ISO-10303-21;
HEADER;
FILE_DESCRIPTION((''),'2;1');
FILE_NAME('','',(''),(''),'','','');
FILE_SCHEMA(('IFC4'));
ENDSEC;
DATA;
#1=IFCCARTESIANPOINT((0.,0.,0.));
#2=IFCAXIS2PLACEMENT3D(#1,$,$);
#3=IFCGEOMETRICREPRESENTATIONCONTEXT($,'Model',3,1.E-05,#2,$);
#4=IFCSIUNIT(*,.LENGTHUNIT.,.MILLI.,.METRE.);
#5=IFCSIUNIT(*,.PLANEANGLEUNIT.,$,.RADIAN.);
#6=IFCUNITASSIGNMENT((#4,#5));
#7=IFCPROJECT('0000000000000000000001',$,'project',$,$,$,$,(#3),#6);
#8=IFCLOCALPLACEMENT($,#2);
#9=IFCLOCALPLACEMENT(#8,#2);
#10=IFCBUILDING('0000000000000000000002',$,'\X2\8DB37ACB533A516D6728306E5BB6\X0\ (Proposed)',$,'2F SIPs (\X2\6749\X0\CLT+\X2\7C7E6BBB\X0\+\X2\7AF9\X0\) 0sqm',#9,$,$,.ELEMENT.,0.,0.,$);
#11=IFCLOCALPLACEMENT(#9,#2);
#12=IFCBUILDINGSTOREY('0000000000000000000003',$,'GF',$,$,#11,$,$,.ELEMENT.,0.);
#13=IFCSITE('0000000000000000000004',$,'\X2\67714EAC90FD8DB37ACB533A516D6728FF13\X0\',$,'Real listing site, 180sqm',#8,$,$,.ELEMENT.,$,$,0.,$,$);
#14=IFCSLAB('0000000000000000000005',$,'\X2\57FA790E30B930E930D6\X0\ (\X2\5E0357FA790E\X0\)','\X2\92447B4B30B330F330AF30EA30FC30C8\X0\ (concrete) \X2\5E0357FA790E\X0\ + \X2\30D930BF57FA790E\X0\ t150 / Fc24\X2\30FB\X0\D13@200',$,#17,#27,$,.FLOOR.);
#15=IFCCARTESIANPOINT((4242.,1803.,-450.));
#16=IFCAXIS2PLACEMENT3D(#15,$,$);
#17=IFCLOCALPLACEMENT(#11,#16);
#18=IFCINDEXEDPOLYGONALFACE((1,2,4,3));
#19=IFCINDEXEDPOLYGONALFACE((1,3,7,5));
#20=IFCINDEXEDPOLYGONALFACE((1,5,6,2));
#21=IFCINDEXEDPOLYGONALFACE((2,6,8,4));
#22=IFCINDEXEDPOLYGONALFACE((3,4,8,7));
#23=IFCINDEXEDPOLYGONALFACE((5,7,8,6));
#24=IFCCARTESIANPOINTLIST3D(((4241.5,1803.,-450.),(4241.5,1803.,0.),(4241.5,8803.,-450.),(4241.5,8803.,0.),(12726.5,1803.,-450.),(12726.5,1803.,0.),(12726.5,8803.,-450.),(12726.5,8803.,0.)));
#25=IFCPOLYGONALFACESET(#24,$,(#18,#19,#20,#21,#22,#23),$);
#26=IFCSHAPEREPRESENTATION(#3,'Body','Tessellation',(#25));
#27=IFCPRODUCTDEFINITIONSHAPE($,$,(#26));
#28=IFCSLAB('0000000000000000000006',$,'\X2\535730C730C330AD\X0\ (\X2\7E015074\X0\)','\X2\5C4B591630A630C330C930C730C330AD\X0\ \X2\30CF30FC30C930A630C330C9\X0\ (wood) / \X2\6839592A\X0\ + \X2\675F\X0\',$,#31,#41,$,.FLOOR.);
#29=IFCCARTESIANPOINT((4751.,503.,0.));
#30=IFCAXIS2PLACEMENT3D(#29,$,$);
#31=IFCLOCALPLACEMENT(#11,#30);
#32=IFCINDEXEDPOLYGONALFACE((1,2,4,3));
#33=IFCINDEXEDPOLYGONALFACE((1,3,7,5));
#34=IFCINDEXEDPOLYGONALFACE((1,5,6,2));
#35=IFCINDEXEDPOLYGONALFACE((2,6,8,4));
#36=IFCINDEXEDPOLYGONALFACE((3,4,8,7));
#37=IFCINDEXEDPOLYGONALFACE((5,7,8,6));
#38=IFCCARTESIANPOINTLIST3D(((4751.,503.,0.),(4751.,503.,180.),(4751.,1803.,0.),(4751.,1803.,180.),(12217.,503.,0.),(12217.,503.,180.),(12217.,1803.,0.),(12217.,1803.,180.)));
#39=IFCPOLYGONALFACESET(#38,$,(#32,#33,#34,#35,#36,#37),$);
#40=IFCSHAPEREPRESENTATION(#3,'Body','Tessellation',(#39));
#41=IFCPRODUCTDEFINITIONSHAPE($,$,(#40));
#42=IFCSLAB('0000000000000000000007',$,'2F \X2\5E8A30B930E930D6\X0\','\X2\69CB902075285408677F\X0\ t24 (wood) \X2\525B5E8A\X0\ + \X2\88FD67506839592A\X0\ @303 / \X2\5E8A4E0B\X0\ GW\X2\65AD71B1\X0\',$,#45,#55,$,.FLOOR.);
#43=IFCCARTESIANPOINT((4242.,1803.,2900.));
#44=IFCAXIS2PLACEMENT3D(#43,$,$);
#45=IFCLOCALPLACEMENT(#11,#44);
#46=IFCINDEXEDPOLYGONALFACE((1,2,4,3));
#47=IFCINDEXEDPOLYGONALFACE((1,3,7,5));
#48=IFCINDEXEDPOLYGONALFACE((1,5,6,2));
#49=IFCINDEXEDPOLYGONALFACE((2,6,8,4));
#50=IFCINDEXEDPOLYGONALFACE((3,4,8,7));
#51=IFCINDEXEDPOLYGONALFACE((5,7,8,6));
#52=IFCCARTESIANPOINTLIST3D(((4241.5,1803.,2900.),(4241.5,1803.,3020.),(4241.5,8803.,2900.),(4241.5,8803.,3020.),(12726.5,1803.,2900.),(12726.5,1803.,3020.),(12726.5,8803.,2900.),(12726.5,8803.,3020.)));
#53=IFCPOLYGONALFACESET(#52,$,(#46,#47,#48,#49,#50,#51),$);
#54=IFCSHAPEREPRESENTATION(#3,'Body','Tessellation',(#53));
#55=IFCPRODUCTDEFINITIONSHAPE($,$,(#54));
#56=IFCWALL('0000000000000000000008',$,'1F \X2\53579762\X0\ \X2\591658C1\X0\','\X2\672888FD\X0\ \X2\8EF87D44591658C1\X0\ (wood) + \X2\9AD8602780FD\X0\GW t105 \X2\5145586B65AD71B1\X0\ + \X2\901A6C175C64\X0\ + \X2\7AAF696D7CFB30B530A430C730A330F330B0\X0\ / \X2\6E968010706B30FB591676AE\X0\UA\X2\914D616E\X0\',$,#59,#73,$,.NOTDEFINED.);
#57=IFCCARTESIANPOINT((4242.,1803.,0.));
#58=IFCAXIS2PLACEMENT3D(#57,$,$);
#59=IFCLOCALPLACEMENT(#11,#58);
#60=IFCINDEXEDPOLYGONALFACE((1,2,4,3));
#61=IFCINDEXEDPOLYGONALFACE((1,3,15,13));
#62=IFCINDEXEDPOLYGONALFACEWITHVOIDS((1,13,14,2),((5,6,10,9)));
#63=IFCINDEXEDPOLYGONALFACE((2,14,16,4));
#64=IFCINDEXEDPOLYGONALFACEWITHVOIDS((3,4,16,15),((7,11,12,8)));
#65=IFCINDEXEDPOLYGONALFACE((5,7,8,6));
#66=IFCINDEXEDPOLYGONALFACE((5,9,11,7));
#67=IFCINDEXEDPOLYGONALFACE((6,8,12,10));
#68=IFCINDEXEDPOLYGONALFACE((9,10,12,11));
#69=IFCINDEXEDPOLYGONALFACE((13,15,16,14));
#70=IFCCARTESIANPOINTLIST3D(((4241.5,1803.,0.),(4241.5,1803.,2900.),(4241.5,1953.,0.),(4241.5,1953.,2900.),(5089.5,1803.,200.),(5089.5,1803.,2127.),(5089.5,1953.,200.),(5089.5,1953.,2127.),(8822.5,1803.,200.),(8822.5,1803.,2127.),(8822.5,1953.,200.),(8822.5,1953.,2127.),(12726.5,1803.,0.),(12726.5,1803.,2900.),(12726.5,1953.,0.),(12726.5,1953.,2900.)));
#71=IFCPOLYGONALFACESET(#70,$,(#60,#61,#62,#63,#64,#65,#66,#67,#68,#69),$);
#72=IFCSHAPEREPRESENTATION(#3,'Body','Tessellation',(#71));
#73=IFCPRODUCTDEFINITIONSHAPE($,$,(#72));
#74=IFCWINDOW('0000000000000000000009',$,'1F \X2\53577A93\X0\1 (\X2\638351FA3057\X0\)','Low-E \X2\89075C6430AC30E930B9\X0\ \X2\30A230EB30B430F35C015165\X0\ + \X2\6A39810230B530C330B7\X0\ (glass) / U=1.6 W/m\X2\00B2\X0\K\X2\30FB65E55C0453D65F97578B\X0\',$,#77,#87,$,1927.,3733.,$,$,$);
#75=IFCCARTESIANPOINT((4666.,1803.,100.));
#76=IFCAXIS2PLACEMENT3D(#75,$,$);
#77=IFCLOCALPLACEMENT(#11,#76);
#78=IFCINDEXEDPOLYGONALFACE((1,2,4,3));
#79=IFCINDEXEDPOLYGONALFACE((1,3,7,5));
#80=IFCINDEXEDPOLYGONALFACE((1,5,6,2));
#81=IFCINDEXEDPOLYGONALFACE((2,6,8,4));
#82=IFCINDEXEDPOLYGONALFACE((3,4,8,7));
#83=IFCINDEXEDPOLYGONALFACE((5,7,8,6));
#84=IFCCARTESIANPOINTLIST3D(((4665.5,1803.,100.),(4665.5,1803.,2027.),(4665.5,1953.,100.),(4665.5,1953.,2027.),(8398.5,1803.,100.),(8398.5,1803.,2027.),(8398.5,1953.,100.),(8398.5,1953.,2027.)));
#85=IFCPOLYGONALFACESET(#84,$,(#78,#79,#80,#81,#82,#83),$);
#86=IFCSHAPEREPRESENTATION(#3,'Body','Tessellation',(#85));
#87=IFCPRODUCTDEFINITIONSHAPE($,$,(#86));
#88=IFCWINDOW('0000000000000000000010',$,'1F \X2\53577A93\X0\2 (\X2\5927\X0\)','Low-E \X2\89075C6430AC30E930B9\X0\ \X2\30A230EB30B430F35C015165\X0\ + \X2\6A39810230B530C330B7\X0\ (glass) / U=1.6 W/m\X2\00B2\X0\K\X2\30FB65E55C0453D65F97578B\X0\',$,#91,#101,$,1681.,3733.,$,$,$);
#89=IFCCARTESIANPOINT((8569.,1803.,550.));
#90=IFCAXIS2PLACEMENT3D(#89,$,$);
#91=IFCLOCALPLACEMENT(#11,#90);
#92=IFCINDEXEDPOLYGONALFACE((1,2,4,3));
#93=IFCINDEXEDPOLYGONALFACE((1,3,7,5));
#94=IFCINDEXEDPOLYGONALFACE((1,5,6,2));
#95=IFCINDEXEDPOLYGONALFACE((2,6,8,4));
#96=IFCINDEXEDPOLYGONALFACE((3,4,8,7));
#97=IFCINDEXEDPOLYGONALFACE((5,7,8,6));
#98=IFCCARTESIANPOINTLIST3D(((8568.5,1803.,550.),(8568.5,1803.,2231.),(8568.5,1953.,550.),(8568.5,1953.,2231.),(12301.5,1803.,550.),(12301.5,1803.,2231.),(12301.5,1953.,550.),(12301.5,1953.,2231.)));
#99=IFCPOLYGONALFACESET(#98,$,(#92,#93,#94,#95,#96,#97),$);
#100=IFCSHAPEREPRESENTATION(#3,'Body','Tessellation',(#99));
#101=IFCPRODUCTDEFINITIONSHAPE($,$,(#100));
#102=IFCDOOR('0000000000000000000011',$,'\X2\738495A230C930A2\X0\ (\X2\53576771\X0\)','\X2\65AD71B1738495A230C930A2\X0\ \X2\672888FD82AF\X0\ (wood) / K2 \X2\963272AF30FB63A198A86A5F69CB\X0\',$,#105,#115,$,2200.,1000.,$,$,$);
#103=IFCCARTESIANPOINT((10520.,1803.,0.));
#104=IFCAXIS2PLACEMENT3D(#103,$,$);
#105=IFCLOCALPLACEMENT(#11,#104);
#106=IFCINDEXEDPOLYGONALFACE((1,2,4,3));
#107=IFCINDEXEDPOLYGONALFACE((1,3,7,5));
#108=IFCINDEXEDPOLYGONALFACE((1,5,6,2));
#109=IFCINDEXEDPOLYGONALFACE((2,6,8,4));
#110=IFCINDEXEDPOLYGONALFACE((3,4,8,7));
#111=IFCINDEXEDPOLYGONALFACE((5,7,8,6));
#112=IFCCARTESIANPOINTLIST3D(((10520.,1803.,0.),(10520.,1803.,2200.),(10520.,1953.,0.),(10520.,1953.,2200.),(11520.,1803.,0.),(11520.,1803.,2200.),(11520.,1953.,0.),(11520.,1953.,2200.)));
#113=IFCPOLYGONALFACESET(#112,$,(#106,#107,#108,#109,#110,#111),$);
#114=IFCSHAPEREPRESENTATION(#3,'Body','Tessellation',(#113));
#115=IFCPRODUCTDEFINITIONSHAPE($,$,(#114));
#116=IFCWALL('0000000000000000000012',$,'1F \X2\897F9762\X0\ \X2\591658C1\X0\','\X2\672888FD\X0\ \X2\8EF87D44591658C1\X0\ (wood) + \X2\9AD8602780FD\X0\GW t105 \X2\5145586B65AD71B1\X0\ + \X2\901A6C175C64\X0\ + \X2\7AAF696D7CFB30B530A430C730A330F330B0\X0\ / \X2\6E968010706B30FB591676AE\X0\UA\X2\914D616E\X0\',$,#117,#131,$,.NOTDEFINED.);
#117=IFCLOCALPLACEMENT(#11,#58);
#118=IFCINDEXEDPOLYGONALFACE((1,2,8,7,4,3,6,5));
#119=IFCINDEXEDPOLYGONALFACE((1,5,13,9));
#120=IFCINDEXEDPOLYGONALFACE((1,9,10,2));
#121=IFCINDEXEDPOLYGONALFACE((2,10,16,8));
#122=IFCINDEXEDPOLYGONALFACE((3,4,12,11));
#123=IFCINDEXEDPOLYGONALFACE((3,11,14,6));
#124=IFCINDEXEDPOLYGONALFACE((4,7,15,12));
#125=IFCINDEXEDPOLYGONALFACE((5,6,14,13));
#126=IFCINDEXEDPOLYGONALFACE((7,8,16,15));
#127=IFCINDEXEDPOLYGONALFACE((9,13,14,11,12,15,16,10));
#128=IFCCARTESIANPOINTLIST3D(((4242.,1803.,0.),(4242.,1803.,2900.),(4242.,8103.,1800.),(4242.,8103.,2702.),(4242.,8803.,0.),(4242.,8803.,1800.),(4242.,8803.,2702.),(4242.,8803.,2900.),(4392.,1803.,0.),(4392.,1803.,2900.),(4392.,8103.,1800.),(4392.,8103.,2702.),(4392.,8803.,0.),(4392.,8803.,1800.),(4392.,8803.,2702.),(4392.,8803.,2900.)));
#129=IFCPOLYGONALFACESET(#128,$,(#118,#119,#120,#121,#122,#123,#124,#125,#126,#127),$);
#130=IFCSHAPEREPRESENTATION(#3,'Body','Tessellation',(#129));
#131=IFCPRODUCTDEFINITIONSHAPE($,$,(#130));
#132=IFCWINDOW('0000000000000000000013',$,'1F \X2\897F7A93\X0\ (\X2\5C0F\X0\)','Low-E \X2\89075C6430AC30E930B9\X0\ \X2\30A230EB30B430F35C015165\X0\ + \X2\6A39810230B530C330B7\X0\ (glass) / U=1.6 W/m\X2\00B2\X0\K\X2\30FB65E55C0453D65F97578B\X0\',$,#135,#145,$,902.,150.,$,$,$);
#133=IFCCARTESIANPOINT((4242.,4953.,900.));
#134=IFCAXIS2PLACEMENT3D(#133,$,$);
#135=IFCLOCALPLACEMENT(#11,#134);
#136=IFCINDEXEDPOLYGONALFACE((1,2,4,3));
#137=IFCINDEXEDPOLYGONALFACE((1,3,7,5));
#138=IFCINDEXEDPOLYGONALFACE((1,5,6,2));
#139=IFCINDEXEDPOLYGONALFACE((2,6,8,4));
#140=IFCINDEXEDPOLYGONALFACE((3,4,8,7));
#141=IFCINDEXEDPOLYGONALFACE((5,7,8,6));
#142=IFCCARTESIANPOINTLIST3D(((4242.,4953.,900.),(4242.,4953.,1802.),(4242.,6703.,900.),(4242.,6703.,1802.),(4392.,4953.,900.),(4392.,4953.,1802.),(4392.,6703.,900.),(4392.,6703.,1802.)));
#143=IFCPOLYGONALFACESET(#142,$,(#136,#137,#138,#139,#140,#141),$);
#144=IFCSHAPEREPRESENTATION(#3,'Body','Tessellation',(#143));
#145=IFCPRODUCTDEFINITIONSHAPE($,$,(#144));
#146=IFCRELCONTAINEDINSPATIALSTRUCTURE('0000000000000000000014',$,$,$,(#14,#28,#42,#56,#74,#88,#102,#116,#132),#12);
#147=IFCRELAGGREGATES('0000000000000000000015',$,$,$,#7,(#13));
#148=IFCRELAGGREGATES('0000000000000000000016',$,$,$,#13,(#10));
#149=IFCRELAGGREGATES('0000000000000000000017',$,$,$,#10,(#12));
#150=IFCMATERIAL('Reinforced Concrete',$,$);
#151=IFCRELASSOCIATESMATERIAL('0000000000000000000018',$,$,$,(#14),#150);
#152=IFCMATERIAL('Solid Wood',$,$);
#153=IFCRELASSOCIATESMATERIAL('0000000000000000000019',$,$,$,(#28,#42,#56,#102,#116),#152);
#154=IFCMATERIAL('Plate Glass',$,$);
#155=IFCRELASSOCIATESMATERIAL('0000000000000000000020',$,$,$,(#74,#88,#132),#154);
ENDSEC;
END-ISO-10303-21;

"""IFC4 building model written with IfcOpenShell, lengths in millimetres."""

from ifc_helpers import new_model, si_unit, frame, frame_2d, origin, place, context, project, spatial, rectangle, extrude, material, element, fill, save


model = new_model("IFC4")

# Units and contexts
model_context = context("Model", 3, precision=1e-05, world=origin())
ifc_project = project(units=[si_unit("LENGTHUNIT", "METRE", prefix="MILLI"), si_unit("PLANEANGLEUNIT", "RADIAN")], contexts=[model_context])

# Site, building, storey
site_placement = place(None, origin())
site = spatial("IfcSite", under=ifc_project, at=site_placement, Name="東京都足立区六木３", ObjectType="Real listing site, 180sqm", CompositionType="ELEMENT", RefElevation=0.0)
building_placement = place(site_placement, origin())
building = spatial("IfcBuilding", under=site, at=building_placement, Name="足立区六木の家 (Proposed)", ObjectType="2F SIPs (杉CLT+籾殻+竹) 0sqm", CompositionType="ELEMENT", ElevationOfRefHeight=0.0, ElevationOfTerrain=0.0)
storey_placement = place(building_placement, origin())
storey = spatial("IfcBuildingStorey", under=building, at=storey_placement, Name="GF", CompositionType="ELEMENT", Elevation=0.0)

# Slabs
ifc_material_1 = material(Name="Reinforced Concrete")
slab_1_placement = place(storey_placement, frame((4242.0, 1803.0, -450.0)))
element("IfcSlab", 1, at=slab_1_placement, inside=storey, material=ifc_material_1, Name="基礎スラブ (布基礎)", Description="鉄筋コンクリート (concrete) 布基礎 + ベタ基礎 t150 / Fc24・D13@200", PredefinedType="FLOOR", context=model_context, shape_type="SweptSolid", body=[
    extrude(rectangle(XDim=8485.0, YDim=7000.0, at=frame_2d((4242.0, 3500.0))), frame((4242.0, 1803.0, -450.0)), (0.0, 0.0, 1.0), 450.0),
])
ifc_material_2 = material(Name="Solid Wood")
slab_2_placement = place(storey_placement, frame((4751.0, 503.0, 0.0)))
element("IfcSlab", 2, at=slab_2_placement, inside=storey, material=ifc_material_2, Name="南デッキ (縁側)", Description="屋外ウッドデッキ ハードウッド (wood) / 根太 + 束", PredefinedType="FLOOR", context=model_context, shape_type="SweptSolid", body=[
    extrude(rectangle(XDim=7466.0, YDim=1300.0, at=frame_2d((3733.0, 650.0))), frame((4751.0, 503.0, 0.0)), (0.0, 0.0, 1.0), 180.0),
])
slab_3_placement = place(storey_placement, frame((4242.0, 1803.0, 2900.0)))
element("IfcSlab", 3, at=slab_3_placement, inside=storey, material=ifc_material_2, Name="2F 床スラブ", Description="構造用合板 t24 (wood) 剛床 + 製材根太 @303 / 床下 GW断熱", PredefinedType="FLOOR", context=model_context, shape_type="SweptSolid", body=[
    extrude(rectangle(XDim=8485.0, YDim=7000.0, at=frame_2d((4242.0, 3500.0))), frame((4242.0, 1803.0, 2900.0)), (0.0, 0.0, 1.0), 120.0),
])

# Wall, openings, windows, door
wall_1_placement = place(storey_placement, frame((4242.0, 1803.0, 0.0)))
wall_1 = element("IfcWall", 4, at=wall_1_placement, inside=storey, material=ifc_material_2, Name="1F 南面 外壁", Description="木製 軸組外壁 (wood) + 高性能GW t105 充填断熱 + 通気層 + 窯業系サイディング / 準耐火・外皮UA配慮", PredefinedType="NOTDEFINED", context=model_context, shape_type="SweptSolid", body=[
    extrude(rectangle(XDim=8485.0, YDim=150.0, at=frame_2d((4242.0, 75.0))), frame((4242.0, 1803.0, 0.0)), (0.0, 0.0, 1.0), 2900.0),
])
opening_1_placement = place(storey_placement, frame((4666.0, 1803.0, 100.0)))
opening_1 = element("IfcOpeningElement", 5, at=opening_1_placement, cuts=wall_1, PredefinedType="NOTDEFINED", context=model_context, shape_type="SweptSolid", body=[
    extrude(rectangle(XDim=3733.0, YDim=150.0, at=frame_2d((1866.0, 75.0))), frame((4666.0, 1803.0, 100.0)), (0.0, 0.0, 1.0), 1927.0),
])
opening_2_placement = place(storey_placement, frame((8569.0, 1803.0, 550.0)))
opening_2 = element("IfcOpeningElement", 6, at=opening_2_placement, cuts=wall_1, PredefinedType="NOTDEFINED", context=model_context, shape_type="SweptSolid", body=[
    extrude(rectangle(XDim=3733.0, YDim=150.0, at=frame_2d((1866.0, 75.0))), frame((8569.0, 1803.0, 550.0)), (0.0, 0.0, 1.0), 1681.0),
])
opening_3_placement = place(storey_placement, frame((10520.0, 1803.0, 0.0)))
opening_3 = element("IfcOpeningElement", 7, at=opening_3_placement, cuts=wall_1, PredefinedType="NOTDEFINED", context=model_context, shape_type="SweptSolid", body=[
    extrude(rectangle(XDim=1000.0, YDim=150.0, at=frame_2d((500.0, 75.0))), frame((10520.0, 1803.0, 0.0)), (0.0, 0.0, 1.0), 2200.0),
])
ifc_material_3 = material(Name="Plate Glass")
window_1_placement = place(storey_placement, frame((4666.0, 1803.0, 100.0)))
window_1 = element("IfcWindow", 8, at=window_1_placement, inside=storey, material=ifc_material_3, Name="1F 南窓1 (掃出し)", Description="Low-E 複層ガラス アルゴン封入 + 樹脂サッシ (glass) / U=1.6 W/m²K・日射取得型", OverallHeight=1927.0, OverallWidth=3733.0, context=model_context, shape_type="SweptSolid", body=[
    extrude(rectangle(XDim=3733.0, YDim=150.0, at=frame_2d((1866.0, 75.0))), frame((4666.0, 1803.0, 100.0)), (0.0, 0.0, 1.0), 1927.0),
])
fill(opening_1, window_1)
window_2_placement = place(storey_placement, frame((8569.0, 1803.0, 550.0)))
window_2 = element("IfcWindow", 9, at=window_2_placement, inside=storey, material=ifc_material_3, Name="1F 南窓2 (大)", Description="Low-E 複層ガラス アルゴン封入 + 樹脂サッシ (glass) / U=1.6 W/m²K・日射取得型", OverallHeight=1681.0, OverallWidth=3733.0, context=model_context, shape_type="SweptSolid", body=[
    extrude(rectangle(XDim=3733.0, YDim=150.0, at=frame_2d((1866.0, 75.0))), frame((8569.0, 1803.0, 550.0)), (0.0, 0.0, 1.0), 1681.0),
])
fill(opening_2, window_2)
door_placement = place(storey_placement, frame((10520.0, 1803.0, 0.0)))
door = element("IfcDoor", 10, at=door_placement, inside=storey, material=ifc_material_2, Name="玄関ドア (南東)", Description="断熱玄関ドア 木製芯 (wood) / K2 防犯・採風機構", OverallHeight=2200.0, OverallWidth=1000.0, context=model_context, shape_type="SweptSolid", body=[
    extrude(rectangle(XDim=1000.0, YDim=150.0, at=frame_2d((500.0, 75.0))), frame((10520.0, 1803.0, 0.0)), (0.0, 0.0, 1.0), 2200.0),
])
fill(opening_3, door)

# Wall, opening, window
wall_2_placement = place(storey_placement, frame((4242.0, 1803.0, 0.0)))
wall_2 = element("IfcWall", 11, at=wall_2_placement, inside=storey, material=ifc_material_2, Name="1F 西面 外壁", Description="木製 軸組外壁 (wood) + 高性能GW t105 充填断熱 + 通気層 + 窯業系サイディング / 準耐火・外皮UA配慮", PredefinedType="NOTDEFINED", context=model_context, shape_type="SweptSolid", body=[
    extrude(rectangle(XDim=150.0, YDim=7000.0, at=frame_2d((75.0, 3500.0))), frame((4242.0, 1803.0, 0.0)), (0.0, 0.0, 1.0), 2900.0),
])
opening_4_placement = place(storey_placement, frame((4242.0, 4953.0, 900.0)))
opening_4 = element("IfcOpeningElement", 12, at=opening_4_placement, cuts=wall_2, PredefinedType="NOTDEFINED", context=model_context, shape_type="SweptSolid", body=[
    extrude(rectangle(XDim=150.0, YDim=1750.0, at=frame_2d((75.0, 875.0))), frame((4242.0, 4953.0, 900.0)), (0.0, 0.0, 1.0), 902.0),
])
window_3_placement = place(storey_placement, frame((4242.0, 4953.0, 900.0)))
window_3 = element("IfcWindow", 13, at=window_3_placement, inside=storey, material=ifc_material_3, Name="1F 西窓 (小)", Description="Low-E 複層ガラス アルゴン封入 + 樹脂サッシ (glass) / U=1.6 W/m²K・日射取得型", OverallHeight=902.0, OverallWidth=150.0, context=model_context, shape_type="SweptSolid", body=[
    extrude(rectangle(XDim=150.0, YDim=1750.0, at=frame_2d((75.0, 875.0))), frame((4242.0, 4953.0, 900.0)), (0.0, 0.0, 1.0), 902.0),
])
fill(opening_4, window_3)

save(model, "model.ifc")
